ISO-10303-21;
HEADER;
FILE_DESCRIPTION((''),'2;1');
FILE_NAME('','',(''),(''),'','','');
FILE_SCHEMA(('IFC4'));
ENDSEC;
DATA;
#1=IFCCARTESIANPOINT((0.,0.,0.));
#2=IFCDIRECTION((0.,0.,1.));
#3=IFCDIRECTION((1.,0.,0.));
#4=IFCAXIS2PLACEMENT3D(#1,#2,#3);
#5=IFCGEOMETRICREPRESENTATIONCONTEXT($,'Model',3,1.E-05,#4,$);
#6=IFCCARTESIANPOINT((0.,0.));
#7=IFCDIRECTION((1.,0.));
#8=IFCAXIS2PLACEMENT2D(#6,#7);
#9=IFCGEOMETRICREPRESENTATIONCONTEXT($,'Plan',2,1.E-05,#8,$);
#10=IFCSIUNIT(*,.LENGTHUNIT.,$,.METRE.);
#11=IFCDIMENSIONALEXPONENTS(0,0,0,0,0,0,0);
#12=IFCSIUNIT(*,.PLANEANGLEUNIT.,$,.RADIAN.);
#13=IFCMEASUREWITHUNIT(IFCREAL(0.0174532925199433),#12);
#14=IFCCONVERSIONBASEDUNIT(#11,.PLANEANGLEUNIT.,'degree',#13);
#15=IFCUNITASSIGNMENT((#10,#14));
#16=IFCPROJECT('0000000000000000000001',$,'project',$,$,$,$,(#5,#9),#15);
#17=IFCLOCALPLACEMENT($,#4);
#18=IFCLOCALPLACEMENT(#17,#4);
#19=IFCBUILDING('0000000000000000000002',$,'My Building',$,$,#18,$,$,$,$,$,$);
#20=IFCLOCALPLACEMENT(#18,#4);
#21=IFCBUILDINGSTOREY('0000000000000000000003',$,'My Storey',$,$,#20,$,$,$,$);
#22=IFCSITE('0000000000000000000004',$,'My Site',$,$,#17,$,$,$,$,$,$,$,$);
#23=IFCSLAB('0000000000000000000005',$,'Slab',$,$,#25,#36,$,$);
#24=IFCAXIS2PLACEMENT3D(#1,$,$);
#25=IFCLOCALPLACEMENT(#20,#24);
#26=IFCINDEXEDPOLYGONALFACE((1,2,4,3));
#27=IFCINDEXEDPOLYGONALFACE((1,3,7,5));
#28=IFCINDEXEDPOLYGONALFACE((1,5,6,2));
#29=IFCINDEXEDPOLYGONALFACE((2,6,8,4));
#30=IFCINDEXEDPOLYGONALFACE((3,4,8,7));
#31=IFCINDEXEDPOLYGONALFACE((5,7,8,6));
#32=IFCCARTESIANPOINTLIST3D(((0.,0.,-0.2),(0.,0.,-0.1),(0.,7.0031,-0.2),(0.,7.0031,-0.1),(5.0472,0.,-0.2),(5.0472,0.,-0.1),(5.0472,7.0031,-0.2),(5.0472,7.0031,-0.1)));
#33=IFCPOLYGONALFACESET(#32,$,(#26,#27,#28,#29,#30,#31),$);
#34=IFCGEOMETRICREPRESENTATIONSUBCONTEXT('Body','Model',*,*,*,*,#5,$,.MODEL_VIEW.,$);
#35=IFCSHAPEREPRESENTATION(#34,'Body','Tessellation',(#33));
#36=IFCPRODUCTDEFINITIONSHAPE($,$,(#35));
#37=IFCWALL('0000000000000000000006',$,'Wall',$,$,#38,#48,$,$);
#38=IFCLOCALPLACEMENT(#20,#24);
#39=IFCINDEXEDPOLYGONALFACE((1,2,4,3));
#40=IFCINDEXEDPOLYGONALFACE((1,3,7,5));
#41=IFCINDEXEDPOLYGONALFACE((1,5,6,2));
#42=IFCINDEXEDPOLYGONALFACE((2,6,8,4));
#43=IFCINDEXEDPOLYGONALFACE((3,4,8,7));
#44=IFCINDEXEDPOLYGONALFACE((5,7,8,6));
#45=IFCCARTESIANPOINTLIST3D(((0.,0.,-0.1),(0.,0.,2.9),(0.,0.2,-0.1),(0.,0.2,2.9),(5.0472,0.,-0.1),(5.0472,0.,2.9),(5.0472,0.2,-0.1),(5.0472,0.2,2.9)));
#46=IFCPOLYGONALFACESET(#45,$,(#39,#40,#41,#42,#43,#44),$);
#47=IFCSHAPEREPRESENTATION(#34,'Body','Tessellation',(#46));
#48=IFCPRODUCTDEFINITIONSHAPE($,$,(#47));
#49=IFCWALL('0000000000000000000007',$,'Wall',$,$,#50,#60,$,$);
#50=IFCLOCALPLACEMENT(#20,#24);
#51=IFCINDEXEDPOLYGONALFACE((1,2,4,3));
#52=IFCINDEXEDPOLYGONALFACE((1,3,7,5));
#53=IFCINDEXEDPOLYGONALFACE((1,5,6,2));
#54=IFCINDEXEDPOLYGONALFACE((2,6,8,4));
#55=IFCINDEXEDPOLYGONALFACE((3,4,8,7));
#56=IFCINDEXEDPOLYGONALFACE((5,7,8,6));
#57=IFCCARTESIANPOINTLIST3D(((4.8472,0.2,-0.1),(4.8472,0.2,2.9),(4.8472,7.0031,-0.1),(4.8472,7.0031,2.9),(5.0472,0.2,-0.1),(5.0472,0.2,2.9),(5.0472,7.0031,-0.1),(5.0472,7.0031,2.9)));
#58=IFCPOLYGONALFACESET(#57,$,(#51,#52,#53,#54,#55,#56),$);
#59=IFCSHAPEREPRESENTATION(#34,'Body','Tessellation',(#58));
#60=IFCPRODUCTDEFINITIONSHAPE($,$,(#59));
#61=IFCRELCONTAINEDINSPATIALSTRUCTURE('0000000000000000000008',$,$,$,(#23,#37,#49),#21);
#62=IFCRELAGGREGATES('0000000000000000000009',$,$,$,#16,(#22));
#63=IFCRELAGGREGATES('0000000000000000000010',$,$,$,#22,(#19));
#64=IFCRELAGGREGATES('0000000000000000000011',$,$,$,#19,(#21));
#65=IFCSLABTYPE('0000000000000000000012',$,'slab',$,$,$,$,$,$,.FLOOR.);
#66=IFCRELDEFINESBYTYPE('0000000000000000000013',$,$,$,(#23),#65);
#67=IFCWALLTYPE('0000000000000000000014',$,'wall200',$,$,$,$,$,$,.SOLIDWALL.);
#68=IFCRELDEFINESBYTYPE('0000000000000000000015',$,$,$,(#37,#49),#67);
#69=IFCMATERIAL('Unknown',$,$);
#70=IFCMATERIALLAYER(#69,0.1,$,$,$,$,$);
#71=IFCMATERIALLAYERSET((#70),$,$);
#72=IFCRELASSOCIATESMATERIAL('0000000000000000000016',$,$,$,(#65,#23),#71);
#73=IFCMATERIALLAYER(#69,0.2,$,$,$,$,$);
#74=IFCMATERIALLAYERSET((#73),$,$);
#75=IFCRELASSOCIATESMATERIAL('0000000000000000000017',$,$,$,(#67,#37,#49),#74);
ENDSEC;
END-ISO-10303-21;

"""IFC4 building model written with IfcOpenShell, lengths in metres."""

from ifc_helpers import new_model, entity, si_unit, converted_unit, frame, origin_with_axes, origin_2d_with_axis, place, context, subcontext, project, spatial, line, indexed_curve, outline, extrude, material, layer, layer_set, layer_usage, type_object, element, save


model = new_model("IFC4")

# Units and contexts
model_context = context("Model", 3, precision=1e-05, world=origin_with_axes())
plan_context = context("Plan", 2, precision=1e-05, world=origin_2d_with_axis())
body_context = subcontext(model_context, "Body", "Model", "MODEL_VIEW")
ifc_project = project(units=[si_unit("LENGTHUNIT", "METRE"), converted_unit("PLANEANGLEUNIT", "degree", entity("IfcReal", 0.0174532925199433), si_unit("PLANEANGLEUNIT", "RADIAN"), dimensions=[0, 0, 0, 0, 0, 0, 0])], contexts=[model_context, plan_context])

# Site, building, storey
site_placement = place(None, origin_with_axes())
site = spatial("IfcSite", under=ifc_project, at=site_placement, Name="My Site")
building_placement = place(site_placement, origin_with_axes())
building = spatial("IfcBuilding", under=site, at=building_placement, Name="My Building")
storey_placement = place(building_placement, origin_with_axes())
storey = spatial("IfcBuildingStorey", under=building, at=storey_placement, Name="My Storey")

# Slab
ifc_material = material(Name="Unknown")
ifc_layer_1 = layer(ifc_material, 0.1)
ifc_layer_set_1 = layer_set([ifc_layer_1])
ifc_layer_usage_1 = layer_usage(ifc_layer_set_1, "AXIS3", "POSITIVE", 0.0)
slab_type = type_object("IfcSlabType", Name="slab", PredefinedType="FLOOR", material=ifc_layer_set_1)
slab_placement = place(storey_placement, frame((0.0, 0.0, -0.2), z_axis=(0.0, 0.0, 1.0), x_axis=(1.0, 0.0, 0.0)))
element("IfcSlab", 1, at=slab_placement, inside=storey, type_object=slab_type, material=ifc_layer_usage_1, Name="Slab", context=body_context, shape_type="SweptSolid", body=[
    extrude(outline(indexed_curve([(0.0, 0.0), (5.0472, 0.0), (5.0472, 7.0031), (0.0, 7.0031)], segments=[line(3, 2), line(2, 1), line(1, 4), line(4, 3)], self_intersect=False)), None, (0.0, 0.0, 1.0), 0.1),
])

# Walls
ifc_layer_2 = layer(ifc_material, 0.2)
ifc_layer_set_2 = layer_set([ifc_layer_2])
ifc_layer_usage_2 = layer_usage(ifc_layer_set_2, "AXIS2", "POSITIVE", 0.0)
wall_type = type_object("IfcWallType", Name="wall200", PredefinedType="SOLIDWALL", material=ifc_layer_set_2)
wall_1_placement = place(storey_placement, frame((0.0, 0.0, -0.1), z_axis=(0.0, 0.0, 1.0), x_axis=(1.0, 0.0, 0.0)))
element("IfcWall", 2, at=wall_1_placement, inside=storey, type_object=wall_type, material=ifc_layer_usage_2, Name="Wall", context=body_context, shape_type="SweptSolid", body=[
    extrude(outline(indexed_curve([(0.0, 0.0), (0.0, 0.2), (5.0472, 0.2), (5.0472, 0.0), (0.0, 0.0)], self_intersect=False)), origin_with_axes(), (0.0, 0.0, 1.0), 3.0),
])
ifc_layer_usage_3 = layer_usage(ifc_layer_set_2, "AXIS2", "POSITIVE", 0.0)
wall_2_placement = place(storey_placement, frame((5.0472, 0.2, -0.1), z_axis=(0.0, 0.0, 1.0), x_axis=(0.0, 1.0, 0.0)))
element("IfcWall", 3, at=wall_2_placement, inside=storey, type_object=wall_type, material=ifc_layer_usage_3, Name="Wall", context=body_context, shape_type="SweptSolid", body=[
    extrude(outline(indexed_curve([(0.0, 0.0), (0.0, 0.2), (6.8031, 0.2), (6.8031, 0.0), (0.0, 0.0)], self_intersect=False)), origin_with_axes(), (0.0, 0.0, 1.0), 3.0),
])

save(model, "model.ifc")
